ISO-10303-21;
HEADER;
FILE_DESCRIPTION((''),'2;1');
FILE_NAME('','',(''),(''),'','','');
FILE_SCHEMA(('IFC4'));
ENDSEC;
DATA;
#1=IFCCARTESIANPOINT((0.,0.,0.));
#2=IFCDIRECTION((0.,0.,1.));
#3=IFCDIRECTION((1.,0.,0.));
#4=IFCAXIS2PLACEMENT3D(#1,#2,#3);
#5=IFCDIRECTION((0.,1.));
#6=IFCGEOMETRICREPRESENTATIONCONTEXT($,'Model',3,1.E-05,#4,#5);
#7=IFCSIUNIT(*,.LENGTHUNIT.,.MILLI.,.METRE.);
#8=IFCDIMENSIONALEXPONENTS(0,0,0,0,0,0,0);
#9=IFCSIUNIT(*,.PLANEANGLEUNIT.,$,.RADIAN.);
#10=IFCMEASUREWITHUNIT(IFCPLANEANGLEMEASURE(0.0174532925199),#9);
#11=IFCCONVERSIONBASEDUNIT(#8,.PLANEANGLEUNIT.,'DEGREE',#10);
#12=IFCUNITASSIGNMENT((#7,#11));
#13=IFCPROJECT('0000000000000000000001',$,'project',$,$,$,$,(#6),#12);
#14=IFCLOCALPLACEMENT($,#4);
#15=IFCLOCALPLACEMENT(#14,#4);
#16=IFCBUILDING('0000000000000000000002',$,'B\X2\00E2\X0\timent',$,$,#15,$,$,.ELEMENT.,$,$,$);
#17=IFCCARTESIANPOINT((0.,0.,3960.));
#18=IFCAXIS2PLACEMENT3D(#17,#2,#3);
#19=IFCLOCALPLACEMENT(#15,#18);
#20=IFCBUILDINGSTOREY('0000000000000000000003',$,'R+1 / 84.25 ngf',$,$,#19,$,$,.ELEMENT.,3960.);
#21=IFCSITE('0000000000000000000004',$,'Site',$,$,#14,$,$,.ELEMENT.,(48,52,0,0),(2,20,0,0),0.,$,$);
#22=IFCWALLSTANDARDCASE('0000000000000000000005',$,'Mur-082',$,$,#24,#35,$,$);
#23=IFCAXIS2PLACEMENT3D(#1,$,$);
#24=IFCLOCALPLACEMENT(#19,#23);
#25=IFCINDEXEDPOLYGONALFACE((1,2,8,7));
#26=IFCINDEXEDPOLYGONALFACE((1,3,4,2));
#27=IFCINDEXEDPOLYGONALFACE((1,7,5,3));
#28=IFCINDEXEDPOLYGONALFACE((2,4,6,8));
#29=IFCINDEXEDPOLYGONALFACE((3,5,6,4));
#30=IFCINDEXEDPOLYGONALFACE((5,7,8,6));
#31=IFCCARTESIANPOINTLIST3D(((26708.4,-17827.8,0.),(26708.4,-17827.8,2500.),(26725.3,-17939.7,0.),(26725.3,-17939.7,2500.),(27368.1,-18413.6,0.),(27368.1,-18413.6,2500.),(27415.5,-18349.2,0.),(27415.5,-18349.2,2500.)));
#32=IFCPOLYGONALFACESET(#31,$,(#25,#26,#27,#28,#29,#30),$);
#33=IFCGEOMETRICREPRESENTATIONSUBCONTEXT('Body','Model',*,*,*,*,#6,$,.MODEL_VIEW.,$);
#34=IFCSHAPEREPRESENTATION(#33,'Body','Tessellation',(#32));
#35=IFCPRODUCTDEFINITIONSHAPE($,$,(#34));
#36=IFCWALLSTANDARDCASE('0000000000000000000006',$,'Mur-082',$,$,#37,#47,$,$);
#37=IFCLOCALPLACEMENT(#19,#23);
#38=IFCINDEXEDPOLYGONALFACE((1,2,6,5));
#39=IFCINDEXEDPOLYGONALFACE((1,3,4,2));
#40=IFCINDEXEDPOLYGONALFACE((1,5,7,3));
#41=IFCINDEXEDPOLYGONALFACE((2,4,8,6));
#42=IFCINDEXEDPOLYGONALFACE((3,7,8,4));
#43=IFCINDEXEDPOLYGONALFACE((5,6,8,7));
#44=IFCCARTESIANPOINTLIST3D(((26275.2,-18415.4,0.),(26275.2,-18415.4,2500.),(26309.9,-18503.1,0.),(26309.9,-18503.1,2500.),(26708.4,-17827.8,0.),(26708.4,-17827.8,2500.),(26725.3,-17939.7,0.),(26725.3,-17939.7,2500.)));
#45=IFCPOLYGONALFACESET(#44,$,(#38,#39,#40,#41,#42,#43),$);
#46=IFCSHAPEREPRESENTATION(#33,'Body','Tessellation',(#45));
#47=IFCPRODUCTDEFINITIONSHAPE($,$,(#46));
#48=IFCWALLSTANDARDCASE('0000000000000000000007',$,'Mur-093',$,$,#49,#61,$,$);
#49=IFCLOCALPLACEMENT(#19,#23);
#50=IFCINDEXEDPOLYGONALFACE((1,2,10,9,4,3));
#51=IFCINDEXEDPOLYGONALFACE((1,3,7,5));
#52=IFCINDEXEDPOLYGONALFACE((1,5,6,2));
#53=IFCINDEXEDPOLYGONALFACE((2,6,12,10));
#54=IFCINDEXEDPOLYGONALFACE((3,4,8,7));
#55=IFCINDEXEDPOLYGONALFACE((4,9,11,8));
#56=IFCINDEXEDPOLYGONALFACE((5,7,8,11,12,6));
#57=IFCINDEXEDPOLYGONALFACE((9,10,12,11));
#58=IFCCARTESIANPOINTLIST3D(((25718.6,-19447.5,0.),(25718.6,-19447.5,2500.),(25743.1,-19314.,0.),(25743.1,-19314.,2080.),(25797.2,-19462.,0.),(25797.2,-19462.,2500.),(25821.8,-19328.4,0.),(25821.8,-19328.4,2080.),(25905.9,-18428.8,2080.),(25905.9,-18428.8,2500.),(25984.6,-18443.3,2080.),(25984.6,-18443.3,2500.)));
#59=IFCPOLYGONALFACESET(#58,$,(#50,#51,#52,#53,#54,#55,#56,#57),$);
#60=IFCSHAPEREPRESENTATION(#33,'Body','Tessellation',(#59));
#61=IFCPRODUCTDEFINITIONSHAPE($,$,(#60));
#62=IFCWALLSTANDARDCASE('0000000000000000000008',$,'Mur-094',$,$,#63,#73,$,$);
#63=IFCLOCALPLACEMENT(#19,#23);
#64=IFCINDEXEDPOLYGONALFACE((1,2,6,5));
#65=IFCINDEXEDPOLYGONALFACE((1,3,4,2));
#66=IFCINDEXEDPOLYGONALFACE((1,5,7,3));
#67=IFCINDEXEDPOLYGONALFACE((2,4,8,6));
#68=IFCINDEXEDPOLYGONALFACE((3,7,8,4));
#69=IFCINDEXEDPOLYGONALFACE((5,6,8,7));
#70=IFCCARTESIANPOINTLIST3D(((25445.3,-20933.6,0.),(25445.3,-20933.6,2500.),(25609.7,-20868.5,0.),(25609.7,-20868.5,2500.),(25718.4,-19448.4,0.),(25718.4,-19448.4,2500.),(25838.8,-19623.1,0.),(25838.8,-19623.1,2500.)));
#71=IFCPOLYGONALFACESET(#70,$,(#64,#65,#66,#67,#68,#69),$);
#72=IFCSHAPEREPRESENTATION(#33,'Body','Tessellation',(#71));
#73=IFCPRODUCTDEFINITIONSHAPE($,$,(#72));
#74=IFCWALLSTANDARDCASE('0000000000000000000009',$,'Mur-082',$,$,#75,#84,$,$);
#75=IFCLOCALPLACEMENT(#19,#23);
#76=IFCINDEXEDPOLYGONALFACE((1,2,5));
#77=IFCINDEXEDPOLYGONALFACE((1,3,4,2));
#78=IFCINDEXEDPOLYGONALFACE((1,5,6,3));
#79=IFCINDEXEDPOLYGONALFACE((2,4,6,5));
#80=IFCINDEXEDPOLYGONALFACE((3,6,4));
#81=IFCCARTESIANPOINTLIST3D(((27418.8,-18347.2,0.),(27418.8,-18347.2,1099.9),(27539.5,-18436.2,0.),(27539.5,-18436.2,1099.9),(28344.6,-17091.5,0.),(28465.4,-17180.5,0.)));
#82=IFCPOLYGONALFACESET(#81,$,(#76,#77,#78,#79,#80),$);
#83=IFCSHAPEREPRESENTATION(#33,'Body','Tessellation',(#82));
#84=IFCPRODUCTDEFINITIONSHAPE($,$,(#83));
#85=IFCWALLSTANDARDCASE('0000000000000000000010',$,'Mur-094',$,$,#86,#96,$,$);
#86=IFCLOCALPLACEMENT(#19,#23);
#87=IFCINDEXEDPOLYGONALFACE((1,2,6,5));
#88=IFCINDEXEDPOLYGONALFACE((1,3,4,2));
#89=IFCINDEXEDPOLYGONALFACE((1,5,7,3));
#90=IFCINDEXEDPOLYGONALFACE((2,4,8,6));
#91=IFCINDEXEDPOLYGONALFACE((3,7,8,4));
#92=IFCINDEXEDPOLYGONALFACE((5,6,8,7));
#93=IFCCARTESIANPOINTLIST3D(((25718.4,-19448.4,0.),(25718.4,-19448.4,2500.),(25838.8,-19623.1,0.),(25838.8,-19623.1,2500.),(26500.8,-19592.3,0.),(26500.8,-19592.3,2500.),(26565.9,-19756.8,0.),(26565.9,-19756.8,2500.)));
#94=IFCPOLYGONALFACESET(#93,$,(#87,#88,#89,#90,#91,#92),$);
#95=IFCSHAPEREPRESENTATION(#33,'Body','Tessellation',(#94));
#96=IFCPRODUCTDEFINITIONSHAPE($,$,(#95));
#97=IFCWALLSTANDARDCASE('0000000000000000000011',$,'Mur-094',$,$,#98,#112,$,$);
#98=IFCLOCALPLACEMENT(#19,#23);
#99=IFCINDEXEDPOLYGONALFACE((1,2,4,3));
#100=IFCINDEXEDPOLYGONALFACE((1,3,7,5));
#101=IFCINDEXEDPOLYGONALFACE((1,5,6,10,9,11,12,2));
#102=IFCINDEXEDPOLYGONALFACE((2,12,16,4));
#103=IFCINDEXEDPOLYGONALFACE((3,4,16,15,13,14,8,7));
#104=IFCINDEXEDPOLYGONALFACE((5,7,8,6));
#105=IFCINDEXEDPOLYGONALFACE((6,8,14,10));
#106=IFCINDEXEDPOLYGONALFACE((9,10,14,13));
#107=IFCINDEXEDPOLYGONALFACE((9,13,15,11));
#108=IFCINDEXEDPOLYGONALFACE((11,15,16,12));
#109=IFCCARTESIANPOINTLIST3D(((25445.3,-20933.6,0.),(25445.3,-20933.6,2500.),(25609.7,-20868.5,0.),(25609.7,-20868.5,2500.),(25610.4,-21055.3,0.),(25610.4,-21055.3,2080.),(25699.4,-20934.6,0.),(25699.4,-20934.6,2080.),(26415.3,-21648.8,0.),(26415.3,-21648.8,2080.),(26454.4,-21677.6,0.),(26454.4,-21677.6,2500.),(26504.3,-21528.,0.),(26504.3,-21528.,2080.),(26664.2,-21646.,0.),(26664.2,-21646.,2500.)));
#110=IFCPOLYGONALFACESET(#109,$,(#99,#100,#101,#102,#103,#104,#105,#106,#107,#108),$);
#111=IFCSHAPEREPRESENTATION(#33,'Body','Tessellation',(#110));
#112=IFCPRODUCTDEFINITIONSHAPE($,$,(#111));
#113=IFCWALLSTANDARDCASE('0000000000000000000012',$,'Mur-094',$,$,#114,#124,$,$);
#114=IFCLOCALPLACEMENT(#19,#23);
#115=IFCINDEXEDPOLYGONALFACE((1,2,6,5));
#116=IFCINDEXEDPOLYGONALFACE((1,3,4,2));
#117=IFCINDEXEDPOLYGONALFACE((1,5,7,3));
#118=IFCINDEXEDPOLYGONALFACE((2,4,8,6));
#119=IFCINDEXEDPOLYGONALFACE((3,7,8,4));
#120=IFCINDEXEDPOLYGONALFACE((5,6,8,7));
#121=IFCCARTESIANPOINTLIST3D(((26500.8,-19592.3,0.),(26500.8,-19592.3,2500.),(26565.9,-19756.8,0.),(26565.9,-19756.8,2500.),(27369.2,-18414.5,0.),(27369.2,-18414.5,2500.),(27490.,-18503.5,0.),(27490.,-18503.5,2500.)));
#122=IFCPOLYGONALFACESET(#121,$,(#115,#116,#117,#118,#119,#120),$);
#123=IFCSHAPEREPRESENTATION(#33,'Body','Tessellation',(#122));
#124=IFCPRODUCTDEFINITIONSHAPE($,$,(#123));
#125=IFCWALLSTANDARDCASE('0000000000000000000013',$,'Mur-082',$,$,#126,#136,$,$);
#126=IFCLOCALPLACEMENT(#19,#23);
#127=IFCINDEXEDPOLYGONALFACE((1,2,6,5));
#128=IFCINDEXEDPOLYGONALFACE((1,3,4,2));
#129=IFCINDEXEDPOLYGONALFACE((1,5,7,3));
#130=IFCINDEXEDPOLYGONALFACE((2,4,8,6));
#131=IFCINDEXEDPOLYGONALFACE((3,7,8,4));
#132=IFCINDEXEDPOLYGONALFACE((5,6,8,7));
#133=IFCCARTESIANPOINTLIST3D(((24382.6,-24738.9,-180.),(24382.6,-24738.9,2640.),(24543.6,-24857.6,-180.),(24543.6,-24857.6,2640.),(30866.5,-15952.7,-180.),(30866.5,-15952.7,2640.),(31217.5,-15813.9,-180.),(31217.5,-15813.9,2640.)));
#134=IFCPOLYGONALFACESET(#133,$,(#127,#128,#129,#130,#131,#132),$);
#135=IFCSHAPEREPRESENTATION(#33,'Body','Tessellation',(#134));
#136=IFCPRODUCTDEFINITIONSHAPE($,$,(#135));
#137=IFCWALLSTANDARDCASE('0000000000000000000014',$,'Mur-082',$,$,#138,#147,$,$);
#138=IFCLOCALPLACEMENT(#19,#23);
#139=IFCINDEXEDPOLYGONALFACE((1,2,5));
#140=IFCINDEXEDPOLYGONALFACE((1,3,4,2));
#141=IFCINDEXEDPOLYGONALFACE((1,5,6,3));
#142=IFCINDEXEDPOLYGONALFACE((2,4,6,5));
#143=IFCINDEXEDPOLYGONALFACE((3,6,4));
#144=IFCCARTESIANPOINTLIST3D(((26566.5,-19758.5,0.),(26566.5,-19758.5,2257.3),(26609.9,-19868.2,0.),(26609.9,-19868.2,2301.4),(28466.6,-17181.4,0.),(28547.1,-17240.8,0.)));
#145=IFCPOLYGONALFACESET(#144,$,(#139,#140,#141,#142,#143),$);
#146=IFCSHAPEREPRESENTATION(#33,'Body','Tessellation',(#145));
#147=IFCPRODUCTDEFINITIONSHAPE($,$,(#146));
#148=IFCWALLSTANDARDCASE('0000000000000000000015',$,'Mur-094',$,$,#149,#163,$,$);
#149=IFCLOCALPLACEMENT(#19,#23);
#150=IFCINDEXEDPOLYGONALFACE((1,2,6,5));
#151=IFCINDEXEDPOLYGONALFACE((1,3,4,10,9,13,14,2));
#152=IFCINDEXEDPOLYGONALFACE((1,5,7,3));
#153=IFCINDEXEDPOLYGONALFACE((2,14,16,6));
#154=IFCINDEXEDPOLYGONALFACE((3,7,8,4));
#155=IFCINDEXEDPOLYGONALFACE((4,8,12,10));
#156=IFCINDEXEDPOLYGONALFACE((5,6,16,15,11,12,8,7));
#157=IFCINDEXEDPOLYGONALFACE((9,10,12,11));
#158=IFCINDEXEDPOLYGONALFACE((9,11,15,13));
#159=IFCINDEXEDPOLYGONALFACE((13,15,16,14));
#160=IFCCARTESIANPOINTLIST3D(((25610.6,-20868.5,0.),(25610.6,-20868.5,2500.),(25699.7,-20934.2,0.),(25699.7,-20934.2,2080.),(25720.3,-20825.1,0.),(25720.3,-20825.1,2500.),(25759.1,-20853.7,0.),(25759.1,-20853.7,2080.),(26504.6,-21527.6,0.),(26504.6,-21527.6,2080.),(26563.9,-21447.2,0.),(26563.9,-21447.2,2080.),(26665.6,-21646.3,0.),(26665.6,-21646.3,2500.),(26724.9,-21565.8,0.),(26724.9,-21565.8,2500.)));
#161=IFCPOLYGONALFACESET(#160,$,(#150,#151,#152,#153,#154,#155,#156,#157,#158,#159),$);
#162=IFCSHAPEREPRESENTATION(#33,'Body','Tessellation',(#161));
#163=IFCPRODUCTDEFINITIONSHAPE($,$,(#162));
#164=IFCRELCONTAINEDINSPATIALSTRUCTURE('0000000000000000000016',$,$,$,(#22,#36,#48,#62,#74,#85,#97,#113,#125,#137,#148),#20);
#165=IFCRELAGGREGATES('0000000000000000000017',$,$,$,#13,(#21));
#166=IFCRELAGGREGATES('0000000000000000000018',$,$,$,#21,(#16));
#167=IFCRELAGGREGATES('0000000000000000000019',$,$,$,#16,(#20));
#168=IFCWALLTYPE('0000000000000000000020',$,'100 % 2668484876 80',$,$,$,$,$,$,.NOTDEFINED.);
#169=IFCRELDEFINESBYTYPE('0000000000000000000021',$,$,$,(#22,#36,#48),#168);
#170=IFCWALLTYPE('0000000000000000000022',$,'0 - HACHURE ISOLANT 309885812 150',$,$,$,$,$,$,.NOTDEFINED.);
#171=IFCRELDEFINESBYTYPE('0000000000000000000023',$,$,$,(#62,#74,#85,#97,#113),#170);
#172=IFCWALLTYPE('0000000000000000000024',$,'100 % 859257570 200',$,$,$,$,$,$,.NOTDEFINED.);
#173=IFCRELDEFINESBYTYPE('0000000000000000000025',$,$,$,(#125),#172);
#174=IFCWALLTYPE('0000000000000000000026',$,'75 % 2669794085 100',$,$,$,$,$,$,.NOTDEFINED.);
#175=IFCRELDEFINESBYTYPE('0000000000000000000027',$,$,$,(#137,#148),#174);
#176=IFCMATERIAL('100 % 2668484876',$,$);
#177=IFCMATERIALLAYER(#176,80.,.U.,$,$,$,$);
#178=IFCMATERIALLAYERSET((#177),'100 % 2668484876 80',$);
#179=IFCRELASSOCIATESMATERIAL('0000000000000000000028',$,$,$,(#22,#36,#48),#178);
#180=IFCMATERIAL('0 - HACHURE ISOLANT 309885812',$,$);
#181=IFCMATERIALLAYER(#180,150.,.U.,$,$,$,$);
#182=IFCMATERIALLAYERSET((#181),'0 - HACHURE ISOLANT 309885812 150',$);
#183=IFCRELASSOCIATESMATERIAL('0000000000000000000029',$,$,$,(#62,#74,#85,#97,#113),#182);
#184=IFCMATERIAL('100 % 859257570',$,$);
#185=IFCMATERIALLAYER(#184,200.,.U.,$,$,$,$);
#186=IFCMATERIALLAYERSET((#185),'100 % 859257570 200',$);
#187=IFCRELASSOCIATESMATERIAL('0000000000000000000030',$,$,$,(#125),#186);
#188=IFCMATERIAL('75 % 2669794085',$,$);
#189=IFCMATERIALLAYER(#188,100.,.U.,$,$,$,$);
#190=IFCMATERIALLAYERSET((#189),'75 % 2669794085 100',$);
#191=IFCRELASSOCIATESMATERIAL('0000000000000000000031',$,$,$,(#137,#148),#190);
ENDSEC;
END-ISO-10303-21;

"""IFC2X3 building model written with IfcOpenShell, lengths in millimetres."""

from ifc_helpers import new_model, entity, si_unit, converted_unit, direction, frame, origin_with_axes, origin_2d_with_axis, place, context, subcontext, project, spatial, polyline, rectangle, outline, extrude, clip, halfspace, material, layer, layer_set, layer_usage, type_object, element, save


model = new_model("IFC2X3")

# Units and contexts
model_context = context("Model", 3, precision=1e-05, world=origin_with_axes(), true_north=direction((0.0, 1.0)))
body_context = subcontext(model_context, "Body", "Model", "MODEL_VIEW")
ifc_project = project(units=[si_unit("LENGTHUNIT", "METRE", prefix="MILLI"), converted_unit("PLANEANGLEUNIT", "DEGREE", entity("IfcPlaneAngleMeasure", 0.0174532925199), si_unit("PLANEANGLEUNIT", "RADIAN"), dimensions=[0, 0, 0, 0, 0, 0, 0])], contexts=[model_context])

# Site, building, storey
site_placement = place(None, origin_with_axes())
site = spatial("IfcSite", under=ifc_project, at=site_placement, Name="Site", CompositionType="ELEMENT", RefLatitude=(48, 52, 0, 0), RefLongitude=(2, 20, 0, 0), RefElevation=0.0)
building_placement = place(site_placement, origin_with_axes())
building = spatial("IfcBuilding", under=site, at=building_placement, Name="Bâtiment", CompositionType="ELEMENT")
storey_placement = place(building_placement, frame((0.0, 0.0, 3960.0), z_axis=(0.0, 0.0, 1.0), x_axis=(1.0, 0.0, 0.0)))
storey = spatial("IfcBuildingStorey", under=building, at=storey_placement, Name="R+1 / 84.25 ngf", CompositionType="ELEMENT", Elevation=3960.0)

# Shared definitions
ifc_material_1 = material(Name="75 % 2669794085")

# Walls
ifc_material_2 = material(Name="100 % 2668484876")
ifc_layer_1 = layer(ifc_material_2, 80.0, ventilated="UNKNOWN")
ifc_layer_set_1 = layer_set([ifc_layer_1], Name="100 % 2668484876 80")
ifc_layer_usage_1 = layer_usage(ifc_layer_set_1, "AXIS2", "NEGATIVE", 80.0)
wall_type_1 = type_object("IfcWallType", Name="100 % 2668484876 80", PredefinedType="NOTDEFINED")
wall_1_placement = place(storey_placement, frame((26660.9, -17892.2, 0.0), z_axis=(0.0, 0.0, 1.0), x_axis=(0.80488, -0.593437, 0.0)))
element("IfcWallStandardCase", 1, at=wall_1_placement, inside=storey, type_object=wall_type_1, material=ifc_layer_usage_1, Name="Mur-082", context=body_context, shape_type="SweptSolid", body=[
    extrude(outline(polyline([(80.0, 0.0), (878.6, 0.0), (878.6, 80.0), (0.0, 80.0), (80.0, 0.0)])), origin_with_axes(), (0.0, 0.0, 1.0), 2500.0),
])
ifc_layer_usage_2 = layer_usage(ifc_layer_set_1, "AXIS2", "NEGATIVE", 80.0)
wall_2_placement = place(storey_placement, frame((26660.9, -17892.2, 0.0), z_axis=(0.0, 0.0, 1.0), x_axis=(-0.593437, -0.80488, 0.0)))
element("IfcWallStandardCase", 2, at=wall_2_placement, inside=storey, type_object=wall_type_1, material=ifc_layer_usage_2, Name="Mur-082", context=body_context, shape_type="SweptSolid", body=[
    extrude(outline(polyline([(-80.0, 0.0), (650.0, 0.0), (700.0, 80.0), (0.0, 80.0), (-80.0, 0.0)])), origin_with_axes(), (0.0, 0.0, 1.0), 2500.0),
])

# Wall, opening
ifc_layer_usage_3 = layer_usage(ifc_layer_set_1, "AXIS2", "NEGATIVE", 80.0)
wall_3_placement = place(storey_placement, frame((25797.2, -19462.0, 0.0), z_axis=(0.0, 0.0, 1.0), x_axis=(0.180879, 0.983505, 0.0)))
wall_3 = element("IfcWallStandardCase", 3, at=wall_3_placement, inside=storey, type_object=wall_type_1, material=ifc_layer_usage_3, Name="Mur-093", context=body_context, shape_type="SweptSolid", body=[
    extrude(outline(polyline([(0.0, 0.0), (1035.8, 0.0), (1035.8, 80.0), (0.0, 80.0), (0.0, 0.0)])), origin_with_axes(), (0.0, 0.0, 1.0), 2500.0),
])
opening_1_placement = place(wall_3_placement, frame((585.8, 0.0, 0.0), z_axis=(0.0, 0.0, 1.0), x_axis=(1.0, 0.0, 0.0)))
element("IfcOpeningElement", 4, at=opening_1_placement, cuts=wall_3, context=body_context, shape_type="SweptSolid", body=[
    extrude(rectangle(XDim=900.0, YDim=2080.0, at=origin_2d_with_axis()), frame((0.0, 160.0, 1040.0), z_axis=(0.0, -1.0, 0.0), x_axis=(1.0, 0.0, 0.0)), (0.0, 0.0, 1.0), 240.0),
])

# Walls
ifc_material_3 = material(Name="0 - HACHURE ISOLANT 309885812")
ifc_layer_2 = layer(ifc_material_3, 150.0, ventilated="UNKNOWN")
ifc_layer_set_2 = layer_set([ifc_layer_2], Name="0 - HACHURE ISOLANT 309885812 150")
wall_type_2 = type_object("IfcWallType", Name="0 - HACHURE ISOLANT 309885812 150", PredefinedType="NOTDEFINED")
ifc_layer_usage_4 = layer_usage(ifc_layer_set_2, "AXIS2", "NEGATIVE", 150.0)
wall_4_placement = place(storey_placement, frame((25718.4, -19448.4, 0.0), z_axis=(0.0, 0.0, 1.0), x_axis=(-0.180879, -0.983505, 0.0)))
element("IfcWallStandardCase", 5, at=wall_4_placement, inside=storey, type_object=wall_type_2, material=ifc_layer_usage_4, Name="Mur-094", context=body_context, shape_type="SweptSolid", body=[
    extrude(outline(polyline([(0.0, 0.0), (1510.1, 0.0), (1416.3, 150.0), (150.0, 150.0), (0.0, 0.0)])), origin_with_axes(), (0.0, 0.0, 1.0), 2500.0),
])
ifc_layer_usage_5 = layer_usage(ifc_layer_set_2, "AXIS2", "NEGATIVE", 150.0)
wall_5_placement = place(storey_placement, frame((28344.6, -17091.5, 0.0), z_axis=(0.0, 0.0, 1.0), x_axis=(-0.593437, -0.80488, 0.0)))
element("IfcWallStandardCase", 6, at=wall_5_placement, inside=storey, type_object=wall_type_2, material=ifc_layer_usage_5, Name="Mur-082", context=body_context, shape_type="Clipping", body=[
    clip(clip(extrude(outline(polyline([(0.0, 0.0), (1560.1, 0.0), (1560.1, 150.0), (0.0, 150.0), (0.0, 0.0)])), origin_with_axes(), (0.0, 0.0, 1.0), 2650.0), halfspace(frame((0.0, 0.0, 0.0), z_axis=(0.576202, 0.0, -0.817307), x_axis=(0.0, 1.0, 0.0)), True)), halfspace(frame((0.0, 0.0, 0.0), z_axis=(0.576202, 0.0, -0.817307), x_axis=(0.0, 1.0, 0.0)), True)),
])
ifc_layer_usage_6 = layer_usage(ifc_layer_set_2, "AXIS2", "POSITIVE", -150.0)
wall_6_placement = place(storey_placement, frame((25718.4, -19448.4, 0.0), z_axis=(0.0, 0.0, 1.0), x_axis=(0.983505, -0.180879, 0.0)))
element("IfcWallStandardCase", 7, at=wall_6_placement, inside=storey, type_object=wall_type_2, material=ifc_layer_usage_6, Name="Mur-094", context=body_context, shape_type="SweptSolid", body=[
    extrude(outline(polyline([(150.0, -150.0), (889.3, -150.0), (795.5, 0.0), (0.0, 0.0), (150.0, -150.0)])), origin_with_axes(), (0.0, 0.0, 1.0), 2500.0),
])

# Wall, opening
ifc_layer_usage_7 = layer_usage(ifc_layer_set_2, "AXIS2", "POSITIVE", -150.0)
wall_7_placement = place(storey_placement, frame((26454.4, -21677.6, 0.0), z_axis=(0.0, 0.0, 1.0), x_axis=(-0.80488, 0.593437, 0.0)))
wall_7 = element("IfcWallStandardCase", 8, at=wall_7_placement, inside=storey, type_object=wall_type_2, material=ifc_layer_usage_7, Name="Mur-094", context=body_context, shape_type="SweptSolid", body=[
    extrude(outline(polyline([(-150.1, -150.0), (1160.0, -150.0), (1253.7, 0.0), (0.0, 0.0), (-150.1, -150.0)])), origin_with_axes(), (0.0, 0.0, 1.0), 2500.0),
])
opening_2_placement = place(wall_7_placement, frame((548.6, 0.0, 0.0), z_axis=(0.0, 0.0, 1.0), x_axis=(1.0, 0.0, 0.0)))
element("IfcOpeningElement", 9, at=opening_2_placement, cuts=wall_7, context=body_context, shape_type="SweptSolid", body=[
    extrude(rectangle(XDim=1000.0, YDim=2080.0, at=origin_2d_with_axis()), frame((0.0, 150.0, 1040.0), z_axis=(0.0, 1.0, 0.0), x_axis=(-1.0, 0.0, 0.0)), (0.0, 0.0, -1.0), 450.0),
])

# Walls
ifc_layer_usage_8 = layer_usage(ifc_layer_set_2, "AXIS2", "POSITIVE", -150.0)
wall_8_placement = place(storey_placement, frame((26500.8, -19592.3, 0.0), z_axis=(0.0, 0.0, 1.0), x_axis=(0.593437, 0.80488, 0.0)))
element("IfcWallStandardCase", 10, at=wall_8_placement, inside=storey, type_object=wall_type_2, material=ifc_layer_usage_8, Name="Mur-094", context=body_context, shape_type="SweptSolid", body=[
    extrude(outline(polyline([(-93.8, -150.0), (1463.4, -150.0), (1463.4, 0.0), (0.0, 0.0), (-93.8, -150.0)])), origin_with_axes(), (0.0, 0.0, 1.0), 2500.0),
])
ifc_material_4 = material(Name="100 % 859257570")
ifc_layer_3 = layer(ifc_material_4, 200.0, ventilated="UNKNOWN")
ifc_layer_set_3 = layer_set([ifc_layer_3], Name="100 % 859257570 200")
ifc_layer_usage_9 = layer_usage(ifc_layer_set_3, "AXIS2", "POSITIVE", -200.0)
wall_type_3 = type_object("IfcWallType", Name="100 % 859257570 200", PredefinedType="NOTDEFINED")
wall_9_placement = place(storey_placement, frame((31217.5, -15813.9, -180.0), z_axis=(0.0, 0.0, 1.0), x_axis=(-0.593784, -0.804624, 0.0)))
element("IfcWallStandardCase", 11, at=wall_9_placement, inside=storey, type_object=wall_type_3, material=ifc_layer_usage_9, Name="Mur-082", context=body_context, shape_type="SweptSolid", body=[
    extrude(outline(polyline([(320.1, -200.0), (11239.7, -200.0), (11239.7, 0.0), (0.0, 0.0), (320.1, -200.0)])), origin_with_axes(), (0.0, 0.0, 1.0), 2820.0),
])
ifc_layer_4 = layer(ifc_material_1, 100.0, ventilated="UNKNOWN")
ifc_layer_set_4 = layer_set([ifc_layer_4], Name="75 % 2669794085 100")
ifc_layer_usage_10 = layer_usage(ifc_layer_set_4, "AXIS2", "NEGATIVE", 0.0)
wall_type_4 = type_object("IfcWallType", Name="75 % 2669794085 100", PredefinedType="NOTDEFINED")
wall_10_placement = place(storey_placement, frame((28547.1, -17240.8, 0.0), z_axis=(0.0, 0.0, 1.0), x_axis=(-0.593437, -0.80488, 0.0)))
element("IfcWallStandardCase", 12, at=wall_10_placement, inside=storey, type_object=wall_type_4, material=ifc_layer_usage_10, Name="Mur-082", context=body_context, shape_type="Clipping", body=[
    clip(extrude(outline(polyline([(0.0, -100.0), (3201.8, -100.0), (3264.3, 0.0), (0.0, 0.0), (0.0, -100.0)])), origin_with_axes(), (0.0, 0.0, 1.0), 2550.0), halfspace(frame((0.0, 0.0, 0.0), z_axis=(0.576202, 0.0, -0.817307), x_axis=(0.0, 1.0, 0.0)), True)),
])

# Wall, opening
ifc_layer_usage_11 = layer_usage(ifc_layer_set_4, "AXIS2", "POSITIVE", 0.0)
wall_11_placement = place(storey_placement, frame((26724.9, -21565.8, 0.0), z_axis=(0.0, 0.0, 1.0), x_axis=(-0.80488, 0.593437, 0.0)))
wall_11 = element("IfcWallStandardCase", 13, at=wall_11_placement, inside=storey, type_object=wall_type_4, material=ifc_layer_usage_11, Name="Mur-094", context=body_context, shape_type="SweptSolid", body=[
    extrude(outline(polyline([(0.0, 0.0), (1248.2, 0.0), (1310.7, 100.0), (0.0, 100.0), (0.0, 0.0)])), origin_with_axes(), (0.0, 0.0, 1.0), 2500.0),
])
opening_3_placement = place(wall_11_placement, frame((700.0, 0.0, 0.0), z_axis=(0.0, 0.0, 1.0), x_axis=(1.0, 0.0, 0.0)))
element("IfcOpeningElement", 14, at=opening_3_placement, cuts=wall_11, context=body_context, shape_type="SweptSolid", body=[
    extrude(rectangle(XDim=1000.0, YDim=2080.0, at=origin_2d_with_axis()), frame((0.0, 200.0, 1040.0), z_axis=(0.0, 1.0, 0.0), x_axis=(-1.0, 0.0, 0.0)), (0.0, 0.0, -1.0), 300.0),
])

save(model, "model.ifc")
